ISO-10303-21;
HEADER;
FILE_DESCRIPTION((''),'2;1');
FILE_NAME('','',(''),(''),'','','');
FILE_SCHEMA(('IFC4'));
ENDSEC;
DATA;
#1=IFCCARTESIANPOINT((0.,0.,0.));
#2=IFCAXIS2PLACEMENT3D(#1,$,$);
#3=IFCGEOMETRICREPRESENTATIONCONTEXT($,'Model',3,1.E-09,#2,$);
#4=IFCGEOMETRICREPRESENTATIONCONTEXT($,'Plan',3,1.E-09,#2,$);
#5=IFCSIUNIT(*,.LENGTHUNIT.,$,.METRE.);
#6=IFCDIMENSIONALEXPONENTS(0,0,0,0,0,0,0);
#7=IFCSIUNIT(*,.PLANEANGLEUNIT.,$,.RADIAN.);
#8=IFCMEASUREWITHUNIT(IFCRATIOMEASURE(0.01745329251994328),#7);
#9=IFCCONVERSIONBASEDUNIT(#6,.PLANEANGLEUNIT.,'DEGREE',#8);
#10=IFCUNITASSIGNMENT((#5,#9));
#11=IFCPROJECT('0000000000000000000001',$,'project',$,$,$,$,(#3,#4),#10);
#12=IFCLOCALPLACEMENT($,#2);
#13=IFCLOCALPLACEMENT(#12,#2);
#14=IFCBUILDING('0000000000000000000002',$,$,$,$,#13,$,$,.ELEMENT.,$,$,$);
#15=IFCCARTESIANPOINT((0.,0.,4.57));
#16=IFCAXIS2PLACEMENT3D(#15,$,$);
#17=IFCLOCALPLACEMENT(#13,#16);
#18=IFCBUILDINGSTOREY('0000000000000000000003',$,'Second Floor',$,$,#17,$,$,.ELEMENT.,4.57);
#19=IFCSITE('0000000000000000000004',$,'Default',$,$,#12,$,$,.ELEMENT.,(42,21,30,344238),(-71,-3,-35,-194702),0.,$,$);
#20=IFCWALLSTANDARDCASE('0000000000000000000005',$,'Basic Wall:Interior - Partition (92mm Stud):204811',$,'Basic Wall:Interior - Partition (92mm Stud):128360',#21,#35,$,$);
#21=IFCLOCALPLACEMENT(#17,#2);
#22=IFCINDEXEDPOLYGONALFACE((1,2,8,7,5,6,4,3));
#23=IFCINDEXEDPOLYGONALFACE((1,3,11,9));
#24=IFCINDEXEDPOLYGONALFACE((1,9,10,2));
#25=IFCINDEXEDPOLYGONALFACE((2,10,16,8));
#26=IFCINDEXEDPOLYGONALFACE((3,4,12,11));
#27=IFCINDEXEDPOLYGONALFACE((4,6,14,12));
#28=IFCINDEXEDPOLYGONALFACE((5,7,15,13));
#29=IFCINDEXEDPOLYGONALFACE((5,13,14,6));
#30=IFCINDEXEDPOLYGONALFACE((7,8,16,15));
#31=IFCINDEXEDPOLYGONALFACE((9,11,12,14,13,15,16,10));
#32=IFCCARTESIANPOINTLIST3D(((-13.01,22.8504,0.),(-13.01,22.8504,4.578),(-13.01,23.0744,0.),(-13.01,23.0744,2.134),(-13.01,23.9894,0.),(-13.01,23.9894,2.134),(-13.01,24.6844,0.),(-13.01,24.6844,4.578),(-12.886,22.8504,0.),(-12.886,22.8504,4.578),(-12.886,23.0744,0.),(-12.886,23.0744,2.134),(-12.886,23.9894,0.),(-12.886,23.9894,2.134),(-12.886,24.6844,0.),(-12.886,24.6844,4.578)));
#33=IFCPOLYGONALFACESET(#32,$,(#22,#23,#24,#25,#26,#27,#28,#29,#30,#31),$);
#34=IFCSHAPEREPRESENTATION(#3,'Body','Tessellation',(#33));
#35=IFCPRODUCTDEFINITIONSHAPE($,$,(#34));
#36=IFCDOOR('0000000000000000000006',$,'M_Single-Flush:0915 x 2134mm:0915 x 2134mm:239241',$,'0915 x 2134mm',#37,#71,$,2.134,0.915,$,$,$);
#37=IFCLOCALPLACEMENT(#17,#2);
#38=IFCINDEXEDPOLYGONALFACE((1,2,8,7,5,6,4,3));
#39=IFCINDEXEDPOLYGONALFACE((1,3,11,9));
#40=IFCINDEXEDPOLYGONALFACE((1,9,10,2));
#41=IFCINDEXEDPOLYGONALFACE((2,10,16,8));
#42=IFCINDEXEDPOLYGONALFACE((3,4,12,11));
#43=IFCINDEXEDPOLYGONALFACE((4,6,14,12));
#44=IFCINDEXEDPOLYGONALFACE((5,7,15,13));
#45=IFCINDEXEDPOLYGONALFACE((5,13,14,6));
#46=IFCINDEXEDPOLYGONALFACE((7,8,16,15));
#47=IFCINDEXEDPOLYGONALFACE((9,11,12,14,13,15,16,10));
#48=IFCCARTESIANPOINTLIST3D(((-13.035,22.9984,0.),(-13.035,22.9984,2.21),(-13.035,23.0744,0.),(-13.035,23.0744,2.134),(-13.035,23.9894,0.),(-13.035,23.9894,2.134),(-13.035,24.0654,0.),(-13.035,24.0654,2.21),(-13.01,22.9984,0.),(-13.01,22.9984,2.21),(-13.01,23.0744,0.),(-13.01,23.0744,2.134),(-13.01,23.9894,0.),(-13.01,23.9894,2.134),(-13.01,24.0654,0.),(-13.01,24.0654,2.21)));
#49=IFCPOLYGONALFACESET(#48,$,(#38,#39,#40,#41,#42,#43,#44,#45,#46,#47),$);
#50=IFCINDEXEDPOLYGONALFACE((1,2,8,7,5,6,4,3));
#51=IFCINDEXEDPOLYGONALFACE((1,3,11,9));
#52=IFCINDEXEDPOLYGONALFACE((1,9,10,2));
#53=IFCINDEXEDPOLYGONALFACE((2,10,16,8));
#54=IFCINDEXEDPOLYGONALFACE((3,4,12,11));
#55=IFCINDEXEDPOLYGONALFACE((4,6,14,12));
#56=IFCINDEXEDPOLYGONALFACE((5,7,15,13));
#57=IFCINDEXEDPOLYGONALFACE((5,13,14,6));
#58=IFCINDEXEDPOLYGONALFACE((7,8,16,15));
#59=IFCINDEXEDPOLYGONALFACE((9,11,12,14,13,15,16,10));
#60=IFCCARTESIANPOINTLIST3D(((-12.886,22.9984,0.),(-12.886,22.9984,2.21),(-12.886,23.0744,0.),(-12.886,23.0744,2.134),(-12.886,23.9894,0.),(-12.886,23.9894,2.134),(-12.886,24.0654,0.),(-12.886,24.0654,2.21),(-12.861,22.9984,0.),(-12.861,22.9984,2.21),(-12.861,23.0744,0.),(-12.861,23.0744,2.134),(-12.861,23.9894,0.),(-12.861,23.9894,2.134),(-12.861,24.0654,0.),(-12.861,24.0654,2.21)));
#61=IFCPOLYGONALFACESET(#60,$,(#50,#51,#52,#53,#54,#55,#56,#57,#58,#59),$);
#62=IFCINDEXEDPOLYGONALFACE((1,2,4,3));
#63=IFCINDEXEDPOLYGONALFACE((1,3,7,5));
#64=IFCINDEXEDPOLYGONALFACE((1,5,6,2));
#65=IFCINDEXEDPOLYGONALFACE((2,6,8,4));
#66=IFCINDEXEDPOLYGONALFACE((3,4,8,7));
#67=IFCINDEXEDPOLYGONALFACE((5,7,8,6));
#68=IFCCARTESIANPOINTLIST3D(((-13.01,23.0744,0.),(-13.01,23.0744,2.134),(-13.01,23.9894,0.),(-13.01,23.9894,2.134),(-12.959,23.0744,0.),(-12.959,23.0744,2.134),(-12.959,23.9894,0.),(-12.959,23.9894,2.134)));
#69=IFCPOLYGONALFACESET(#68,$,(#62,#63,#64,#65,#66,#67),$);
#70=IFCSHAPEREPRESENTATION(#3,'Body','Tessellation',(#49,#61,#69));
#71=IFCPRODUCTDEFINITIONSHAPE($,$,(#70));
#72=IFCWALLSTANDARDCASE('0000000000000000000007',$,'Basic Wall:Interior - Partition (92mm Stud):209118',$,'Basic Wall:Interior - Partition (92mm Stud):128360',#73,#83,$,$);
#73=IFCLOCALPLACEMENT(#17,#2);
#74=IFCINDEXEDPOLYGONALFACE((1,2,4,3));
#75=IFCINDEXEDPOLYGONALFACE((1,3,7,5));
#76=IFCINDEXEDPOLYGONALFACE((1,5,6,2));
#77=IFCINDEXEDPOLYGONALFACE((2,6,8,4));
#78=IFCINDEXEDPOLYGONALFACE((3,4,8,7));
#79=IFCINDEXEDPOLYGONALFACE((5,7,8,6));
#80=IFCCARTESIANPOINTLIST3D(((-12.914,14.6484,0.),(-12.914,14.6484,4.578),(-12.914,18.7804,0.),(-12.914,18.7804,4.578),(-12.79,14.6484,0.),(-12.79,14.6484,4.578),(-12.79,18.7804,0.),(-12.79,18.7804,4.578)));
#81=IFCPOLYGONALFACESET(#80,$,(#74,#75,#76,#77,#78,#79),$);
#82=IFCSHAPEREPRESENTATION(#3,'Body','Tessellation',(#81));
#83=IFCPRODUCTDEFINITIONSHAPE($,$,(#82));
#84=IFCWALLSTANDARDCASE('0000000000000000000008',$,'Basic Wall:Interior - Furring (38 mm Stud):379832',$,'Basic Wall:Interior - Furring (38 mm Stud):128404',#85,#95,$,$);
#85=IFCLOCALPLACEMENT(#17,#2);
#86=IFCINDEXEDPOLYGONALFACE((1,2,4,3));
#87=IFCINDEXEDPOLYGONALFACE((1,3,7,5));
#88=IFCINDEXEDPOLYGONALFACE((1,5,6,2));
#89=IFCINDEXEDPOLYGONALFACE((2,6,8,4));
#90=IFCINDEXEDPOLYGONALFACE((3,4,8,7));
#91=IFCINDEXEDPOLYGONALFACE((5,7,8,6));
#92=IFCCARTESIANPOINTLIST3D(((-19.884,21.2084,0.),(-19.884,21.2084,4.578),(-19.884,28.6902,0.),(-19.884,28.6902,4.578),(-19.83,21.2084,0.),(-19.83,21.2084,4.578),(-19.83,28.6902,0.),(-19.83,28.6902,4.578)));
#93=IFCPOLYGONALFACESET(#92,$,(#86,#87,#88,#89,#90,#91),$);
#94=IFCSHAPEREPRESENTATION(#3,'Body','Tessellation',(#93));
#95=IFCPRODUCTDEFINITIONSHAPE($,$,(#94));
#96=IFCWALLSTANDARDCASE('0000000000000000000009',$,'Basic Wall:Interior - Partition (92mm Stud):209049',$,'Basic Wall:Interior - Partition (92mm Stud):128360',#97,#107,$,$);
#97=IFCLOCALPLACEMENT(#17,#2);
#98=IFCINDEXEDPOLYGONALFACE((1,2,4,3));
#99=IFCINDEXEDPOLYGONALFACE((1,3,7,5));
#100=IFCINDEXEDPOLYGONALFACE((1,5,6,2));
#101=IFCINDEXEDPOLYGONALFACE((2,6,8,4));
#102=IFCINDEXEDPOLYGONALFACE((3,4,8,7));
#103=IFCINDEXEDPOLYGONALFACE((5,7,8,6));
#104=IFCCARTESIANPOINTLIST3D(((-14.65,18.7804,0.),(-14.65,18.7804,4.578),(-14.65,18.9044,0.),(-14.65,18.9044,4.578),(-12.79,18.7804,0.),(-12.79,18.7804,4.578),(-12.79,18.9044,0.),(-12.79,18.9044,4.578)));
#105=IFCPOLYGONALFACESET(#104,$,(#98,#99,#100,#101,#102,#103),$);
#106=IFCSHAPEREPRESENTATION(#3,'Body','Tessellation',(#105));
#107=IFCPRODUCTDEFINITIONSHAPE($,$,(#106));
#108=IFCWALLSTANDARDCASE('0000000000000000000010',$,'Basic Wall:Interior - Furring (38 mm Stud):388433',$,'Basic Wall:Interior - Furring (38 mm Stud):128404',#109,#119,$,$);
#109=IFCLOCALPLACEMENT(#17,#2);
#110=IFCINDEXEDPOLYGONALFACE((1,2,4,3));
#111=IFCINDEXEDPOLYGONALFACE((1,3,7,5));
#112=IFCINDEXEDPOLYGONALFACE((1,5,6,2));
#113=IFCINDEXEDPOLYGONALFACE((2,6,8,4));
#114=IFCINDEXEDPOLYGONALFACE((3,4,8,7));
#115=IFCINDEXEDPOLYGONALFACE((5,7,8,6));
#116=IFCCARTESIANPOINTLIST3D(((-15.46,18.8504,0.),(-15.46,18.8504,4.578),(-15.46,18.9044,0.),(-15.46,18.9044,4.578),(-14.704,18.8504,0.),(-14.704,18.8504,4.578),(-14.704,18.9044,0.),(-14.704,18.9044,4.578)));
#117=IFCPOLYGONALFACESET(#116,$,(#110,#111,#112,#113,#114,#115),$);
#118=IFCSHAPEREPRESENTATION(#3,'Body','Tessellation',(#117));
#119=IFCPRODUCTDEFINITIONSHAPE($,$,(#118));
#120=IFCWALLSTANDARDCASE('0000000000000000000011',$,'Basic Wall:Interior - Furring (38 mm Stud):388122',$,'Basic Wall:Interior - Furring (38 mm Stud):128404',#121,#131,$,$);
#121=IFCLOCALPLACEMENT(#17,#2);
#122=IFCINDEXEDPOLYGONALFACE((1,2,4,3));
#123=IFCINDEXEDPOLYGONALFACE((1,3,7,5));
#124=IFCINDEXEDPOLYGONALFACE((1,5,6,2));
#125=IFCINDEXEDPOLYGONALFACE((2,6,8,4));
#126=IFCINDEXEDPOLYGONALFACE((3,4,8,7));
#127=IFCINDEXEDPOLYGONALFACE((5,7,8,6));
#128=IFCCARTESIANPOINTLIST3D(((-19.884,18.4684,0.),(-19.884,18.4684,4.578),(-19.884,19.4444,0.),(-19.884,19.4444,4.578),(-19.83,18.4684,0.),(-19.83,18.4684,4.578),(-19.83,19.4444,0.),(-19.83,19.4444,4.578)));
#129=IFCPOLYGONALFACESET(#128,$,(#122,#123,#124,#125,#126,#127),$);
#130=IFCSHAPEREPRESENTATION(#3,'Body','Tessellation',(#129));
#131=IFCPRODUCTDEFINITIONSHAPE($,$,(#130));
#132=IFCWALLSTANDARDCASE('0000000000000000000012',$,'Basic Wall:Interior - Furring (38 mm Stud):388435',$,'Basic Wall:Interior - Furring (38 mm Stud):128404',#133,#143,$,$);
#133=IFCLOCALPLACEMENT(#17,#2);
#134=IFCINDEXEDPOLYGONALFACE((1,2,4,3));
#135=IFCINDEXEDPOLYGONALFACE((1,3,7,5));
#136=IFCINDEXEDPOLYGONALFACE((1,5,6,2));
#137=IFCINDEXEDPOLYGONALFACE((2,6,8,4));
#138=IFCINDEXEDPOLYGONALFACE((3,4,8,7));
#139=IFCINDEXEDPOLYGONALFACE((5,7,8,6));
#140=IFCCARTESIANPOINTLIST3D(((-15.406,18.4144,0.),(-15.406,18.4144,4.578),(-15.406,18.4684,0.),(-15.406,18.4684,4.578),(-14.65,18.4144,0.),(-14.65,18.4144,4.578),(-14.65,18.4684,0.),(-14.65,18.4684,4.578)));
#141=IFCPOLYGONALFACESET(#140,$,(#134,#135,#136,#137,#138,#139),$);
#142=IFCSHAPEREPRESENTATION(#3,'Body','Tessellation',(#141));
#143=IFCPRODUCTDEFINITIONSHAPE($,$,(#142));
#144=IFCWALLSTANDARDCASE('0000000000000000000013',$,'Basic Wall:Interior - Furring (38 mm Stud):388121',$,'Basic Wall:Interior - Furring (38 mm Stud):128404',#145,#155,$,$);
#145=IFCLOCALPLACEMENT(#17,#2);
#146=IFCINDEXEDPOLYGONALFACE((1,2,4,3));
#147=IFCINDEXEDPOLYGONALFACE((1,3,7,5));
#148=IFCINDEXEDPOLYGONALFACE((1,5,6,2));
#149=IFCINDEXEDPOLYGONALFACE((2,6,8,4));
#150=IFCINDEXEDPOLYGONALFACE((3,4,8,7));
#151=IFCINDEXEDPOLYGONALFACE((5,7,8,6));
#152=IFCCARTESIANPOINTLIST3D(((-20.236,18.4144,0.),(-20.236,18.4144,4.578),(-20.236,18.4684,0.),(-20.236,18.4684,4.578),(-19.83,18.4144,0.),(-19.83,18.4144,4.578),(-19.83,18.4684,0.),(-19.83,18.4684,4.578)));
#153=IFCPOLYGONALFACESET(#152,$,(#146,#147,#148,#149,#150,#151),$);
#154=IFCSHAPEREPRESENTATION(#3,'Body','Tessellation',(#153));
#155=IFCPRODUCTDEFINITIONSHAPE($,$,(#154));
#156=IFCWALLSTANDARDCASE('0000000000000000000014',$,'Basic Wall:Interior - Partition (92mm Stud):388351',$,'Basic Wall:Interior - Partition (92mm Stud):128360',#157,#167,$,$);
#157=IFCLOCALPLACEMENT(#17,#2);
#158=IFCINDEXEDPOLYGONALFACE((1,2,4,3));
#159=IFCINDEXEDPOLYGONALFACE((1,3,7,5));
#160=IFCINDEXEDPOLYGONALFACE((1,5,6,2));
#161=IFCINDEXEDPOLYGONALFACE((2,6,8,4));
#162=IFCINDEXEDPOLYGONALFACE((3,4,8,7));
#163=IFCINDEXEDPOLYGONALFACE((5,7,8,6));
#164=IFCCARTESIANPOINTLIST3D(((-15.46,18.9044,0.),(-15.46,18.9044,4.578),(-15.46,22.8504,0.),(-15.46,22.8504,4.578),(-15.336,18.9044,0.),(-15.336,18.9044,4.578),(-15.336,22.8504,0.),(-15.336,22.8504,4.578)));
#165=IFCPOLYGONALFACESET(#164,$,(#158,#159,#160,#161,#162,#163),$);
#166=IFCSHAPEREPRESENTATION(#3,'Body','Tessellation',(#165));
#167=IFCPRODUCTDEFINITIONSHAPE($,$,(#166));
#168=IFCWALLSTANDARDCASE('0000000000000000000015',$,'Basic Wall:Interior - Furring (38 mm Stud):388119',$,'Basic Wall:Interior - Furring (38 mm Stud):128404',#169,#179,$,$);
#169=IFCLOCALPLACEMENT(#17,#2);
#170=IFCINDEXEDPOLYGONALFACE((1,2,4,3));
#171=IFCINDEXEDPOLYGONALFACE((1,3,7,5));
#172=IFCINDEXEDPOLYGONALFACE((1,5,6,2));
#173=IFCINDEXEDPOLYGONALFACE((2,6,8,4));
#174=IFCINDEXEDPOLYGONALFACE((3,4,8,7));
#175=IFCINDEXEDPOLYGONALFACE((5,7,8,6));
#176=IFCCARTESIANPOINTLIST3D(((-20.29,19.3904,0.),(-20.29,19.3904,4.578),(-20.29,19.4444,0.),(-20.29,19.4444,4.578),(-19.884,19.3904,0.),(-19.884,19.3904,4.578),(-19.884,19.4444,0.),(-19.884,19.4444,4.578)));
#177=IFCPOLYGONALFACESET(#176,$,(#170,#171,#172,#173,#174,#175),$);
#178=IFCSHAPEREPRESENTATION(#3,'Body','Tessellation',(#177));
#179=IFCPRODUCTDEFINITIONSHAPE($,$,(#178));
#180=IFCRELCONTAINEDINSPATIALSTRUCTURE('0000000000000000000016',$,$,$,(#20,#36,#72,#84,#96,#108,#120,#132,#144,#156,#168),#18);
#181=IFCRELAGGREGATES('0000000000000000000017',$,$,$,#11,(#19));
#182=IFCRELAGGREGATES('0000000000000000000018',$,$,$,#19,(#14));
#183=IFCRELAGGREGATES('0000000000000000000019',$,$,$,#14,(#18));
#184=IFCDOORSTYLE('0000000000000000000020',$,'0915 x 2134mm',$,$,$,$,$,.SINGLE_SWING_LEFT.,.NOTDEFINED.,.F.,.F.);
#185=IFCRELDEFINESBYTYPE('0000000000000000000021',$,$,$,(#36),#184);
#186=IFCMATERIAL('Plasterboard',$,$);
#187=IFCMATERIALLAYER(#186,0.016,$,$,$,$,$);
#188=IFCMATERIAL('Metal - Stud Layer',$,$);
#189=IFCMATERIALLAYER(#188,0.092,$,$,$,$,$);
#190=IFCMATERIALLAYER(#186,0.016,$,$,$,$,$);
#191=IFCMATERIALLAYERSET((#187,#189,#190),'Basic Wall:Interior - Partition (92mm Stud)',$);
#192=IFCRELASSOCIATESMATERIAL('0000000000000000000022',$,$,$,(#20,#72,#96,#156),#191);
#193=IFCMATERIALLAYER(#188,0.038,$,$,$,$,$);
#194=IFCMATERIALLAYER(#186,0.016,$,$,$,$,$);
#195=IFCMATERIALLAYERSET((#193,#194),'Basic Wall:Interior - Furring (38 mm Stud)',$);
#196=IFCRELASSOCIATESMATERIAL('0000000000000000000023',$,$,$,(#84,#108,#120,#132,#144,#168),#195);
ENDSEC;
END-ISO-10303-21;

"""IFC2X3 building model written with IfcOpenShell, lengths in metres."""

from ifc_helpers import new_model, entity, si_unit, converted_unit, frame, frame_2d, origin, origin_2d_with_axis, place, context, project, spatial, polyline, rectangle, outline, extrude, source, transform, mapped, material, layer, layer_set, layer_usage, type_object, type_shapes, element, fill, save


model = new_model("IFC2X3")

# Units and contexts
model_context = context("Model", 3, precision=1e-09, world=origin())
plan_context = context("Plan", 3, precision=1e-09, world=origin())
ifc_project = project(units=[si_unit("LENGTHUNIT", "METRE"), converted_unit("PLANEANGLEUNIT", "DEGREE", entity("IfcRatioMeasure", 0.01745329251994328), si_unit("PLANEANGLEUNIT", "RADIAN"), dimensions=[0, 0, 0, 0, 0, 0, 0])], contexts=[model_context, plan_context])

# Site, building, storey
site_placement = place(None, origin())
site = spatial("IfcSite", under=ifc_project, at=site_placement, Name="Default", CompositionType="ELEMENT", RefLatitude=(42, 21, 30, 344238), RefLongitude=(-71, -3, -35, -194702), RefElevation=0.0)
building_placement = place(site_placement, origin())
building = spatial("IfcBuilding", under=site, at=building_placement, CompositionType="ELEMENT")
storey_placement = place(building_placement, frame((0.0, 0.0, 4.57)))
storey = spatial("IfcBuildingStorey", under=building, at=storey_placement, Name="Second Floor", CompositionType="ELEMENT", Elevation=4.57)

# Shared definitions
ifc_material_1 = material(Name="Plasterboard")
ifc_layer_1 = layer(ifc_material_1, 0.016)
ifc_material_2 = material(Name="Metal - Stud Layer")
ifc_layer_2 = layer(ifc_material_2, 0.092)
ifc_layer_3 = layer(ifc_material_1, 0.016)
ifc_layer_set_1 = layer_set([ifc_layer_1, ifc_layer_2, ifc_layer_3], Name="Basic Wall:Interior - Partition (92mm Stud)")
ifc_layer_usage_1 = layer_usage(ifc_layer_set_1, "AXIS2", "NEGATIVE", 0.062)
door_style_1 = type_object("IfcDoorStyle", Name="0915 x 2134mm", ConstructionType="NOTDEFINED", OperationType="SINGLE_SWING_LEFT", ParameterTakesPrecedence=False, Sizeable=False)
shared_shape_1 = source(origin(), model_context, "Body", "SweptSolid", [
    extrude(outline(polyline([(-0.5335, -1.124), (0.5335, -1.124), (0.5335, 1.086), (0.4575, 1.086), (0.4575, -1.048), (-0.4575, -1.048), (-0.4575, 1.086), (-0.5335, 1.086), (-0.5335, -1.124)])), frame((0.4575, 0.149, 1.086), z_axis=(0.0, -1.0, 0.0), x_axis=(-1.0, 0.0, 0.0)), (0.0, 0.0, 1.0), 0.025),
    extrude(outline(polyline([(-1.124, -0.5335), (1.086, -0.5335), (1.086, -0.4575), (-1.048, -0.4575), (-1.048, 0.4575), (1.086, 0.4575), (1.086, 0.5335), (-1.124, 0.5335), (-1.124, -0.5335)])), frame((0.4575, 0.0, 1.086), z_axis=(0.0, -1.0, 0.0), x_axis=(0.0, 0.0, -1.0)), (0.0, 0.0, 1.0), 0.025),
    extrude(rectangle(XDim=0.915, YDim=0.051, at=origin_2d_with_axis()), frame((0.4575, 0.0985, 0.0)), (0.0, 0.0, 1.0), 2.134),
])
type_shapes(door_style_1, [shared_shape_1])

# Shared definitions
ifc_layer_4 = layer(ifc_material_2, 0.038)
ifc_layer_5 = layer(ifc_material_1, 0.016)
ifc_layer_set_2 = layer_set([ifc_layer_4, ifc_layer_5], Name="Basic Wall:Interior - Furring (38 mm Stud)")
ifc_layer_usage_2 = layer_usage(ifc_layer_set_2, "AXIS2", "POSITIVE", -0.027)

# Wall, opening, door
wall_1_placement = place(storey_placement, frame((-12.948, 22.8504, 0.0), z_axis=(0.0, 0.0, 1.0), x_axis=(0.0, 1.0, 0.0)))
wall_1 = element("IfcWallStandardCase", 1, at=wall_1_placement, inside=storey, material=ifc_layer_usage_1, Name="Basic Wall:Interior - Partition (92mm Stud):204811", ObjectType="Basic Wall:Interior - Partition (92mm Stud):128360", context=model_context, shape_type="SweptSolid", body=[
    extrude(rectangle(XDim=1.834, YDim=0.124, at=frame_2d((0.917, 0.0), x_axis=(-1.0, 0.0))), origin(), (0.0, 0.0, 1.0), 4.578),
])
opening_1_placement = place(wall_1_placement, frame((0.224, -0.062, 0.0)))
opening_1 = element("IfcOpeningElement", 2, at=opening_1_placement, cuts=wall_1, ObjectType="Opening", context=model_context, shape_type="SweptSolid", body=[
    extrude(rectangle(XDim=0.915, YDim=2.134, at=frame_2d((1.067, 0.4575), x_axis=(0.0, -1.0))), frame((0.0, 0.0, 0.0), z_axis=(0.0, 1.0, 0.0), x_axis=(0.0, 0.0, 1.0)), (0.0, 0.0, 1.0), 0.124),
])
door_1_placement = place(opening_1_placement, origin())
door_1 = element("IfcDoor", 3, at=door_1_placement, inside=storey, type_object=door_style_1, Name="M_Single-Flush:0915 x 2134mm:0915 x 2134mm:239241", ObjectType="0915 x 2134mm", OverallHeight=2.134, OverallWidth=0.915, context=model_context, shape_type="MappedRepresentation", body=[
    mapped(shared_shape_1, transform((0.0, 0.0, 0.0), scale=1.0)),
])
fill(opening_1, door_1)

# Walls
wall_2_placement = place(storey_placement, frame((-12.852, 18.7804, 0.0), z_axis=(0.0, 0.0, 1.0), x_axis=(0.0, -1.0, 0.0)))
element("IfcWallStandardCase", 4, at=wall_2_placement, inside=storey, material=ifc_layer_usage_1, Name="Basic Wall:Interior - Partition (92mm Stud):209118", ObjectType="Basic Wall:Interior - Partition (92mm Stud):128360", context=model_context, shape_type="SweptSolid", body=[
    extrude(rectangle(XDim=4.132, YDim=0.124, at=frame_2d((2.066, 0.0), x_axis=(-1.0, 0.0))), origin(), (0.0, 0.0, 1.0), 4.578),
])
ifc_layer_usage_3 = layer_usage(ifc_layer_set_2, "AXIS2", "NEGATIVE", 0.027)
wall_3_placement = place(storey_placement, frame((-19.857, 21.2084, 0.0), z_axis=(0.0, 0.0, 1.0), x_axis=(0.0, 1.0, 0.0)))
element("IfcWallStandardCase", 5, at=wall_3_placement, inside=storey, material=ifc_layer_usage_3, Name="Basic Wall:Interior - Furring (38 mm Stud):379832", ObjectType="Basic Wall:Interior - Furring (38 mm Stud):128404", context=model_context, shape_type="SweptSolid", body=[
    extrude(rectangle(XDim=7.4818, YDim=0.054, at=frame_2d((3.7409, 0.0), x_axis=(-1.0, 0.0))), origin(), (0.0, 0.0, 1.0), 4.578),
])
wall_4_placement = place(storey_placement, frame((-14.65, 18.8424, 0.0)))
element("IfcWallStandardCase", 6, at=wall_4_placement, inside=storey, material=ifc_layer_usage_1, Name="Basic Wall:Interior - Partition (92mm Stud):209049", ObjectType="Basic Wall:Interior - Partition (92mm Stud):128360", context=model_context, shape_type="SweptSolid", body=[
    extrude(rectangle(XDim=1.86, YDim=0.124, at=frame_2d((0.93, 0.0), x_axis=(-1.0, 0.0))), origin(), (0.0, 0.0, 1.0), 4.578),
])
wall_5_placement = place(storey_placement, frame((-15.46, 18.8774, 0.0)))
element("IfcWallStandardCase", 7, at=wall_5_placement, inside=storey, material=ifc_layer_usage_2, Name="Basic Wall:Interior - Furring (38 mm Stud):388433", ObjectType="Basic Wall:Interior - Furring (38 mm Stud):128404", context=model_context, shape_type="SweptSolid", body=[
    extrude(rectangle(XDim=0.756, YDim=0.054, at=frame_2d((0.378, 0.0), x_axis=(-1.0, 0.0))), origin(), (0.0, 0.0, 1.0), 4.578),
])
wall_6_placement = place(storey_placement, frame((-19.857, 19.4444, 0.0), z_axis=(0.0, 0.0, 1.0), x_axis=(0.0, -1.0, 0.0)))
element("IfcWallStandardCase", 8, at=wall_6_placement, inside=storey, material=ifc_layer_usage_2, Name="Basic Wall:Interior - Furring (38 mm Stud):388122", ObjectType="Basic Wall:Interior - Furring (38 mm Stud):128404", context=model_context, shape_type="SweptSolid", body=[
    extrude(rectangle(XDim=0.976, YDim=0.054, at=frame_2d((0.488, 0.0), x_axis=(-1.0, 0.0))), origin(), (0.0, 0.0, 1.0), 4.578),
])
wall_7_placement = place(storey_placement, frame((-14.65, 18.4414, 0.0), z_axis=(0.0, 0.0, 1.0), x_axis=(-1.0, 0.0, 0.0)))
element("IfcWallStandardCase", 9, at=wall_7_placement, inside=storey, material=ifc_layer_usage_2, Name="Basic Wall:Interior - Furring (38 mm Stud):388435", ObjectType="Basic Wall:Interior - Furring (38 mm Stud):128404", context=model_context, shape_type="SweptSolid", body=[
    extrude(rectangle(XDim=0.756, YDim=0.054, at=frame_2d((0.378, 0.0), x_axis=(-1.0, 0.0))), origin(), (0.0, 0.0, 1.0), 4.578),
])
wall_8_placement = place(storey_placement, frame((-19.83, 18.4414, 0.0), z_axis=(0.0, 0.0, 1.0), x_axis=(-1.0, 0.0, 0.0)))
element("IfcWallStandardCase", 10, at=wall_8_placement, inside=storey, material=ifc_layer_usage_2, Name="Basic Wall:Interior - Furring (38 mm Stud):388121", ObjectType="Basic Wall:Interior - Furring (38 mm Stud):128404", context=model_context, shape_type="SweptSolid", body=[
    extrude(rectangle(XDim=0.406, YDim=0.054, at=frame_2d((0.203, 0.0), x_axis=(-1.0, 0.0))), origin(), (0.0, 0.0, 1.0), 4.578),
])
wall_9_placement = place(storey_placement, frame((-15.398, 18.9044, 0.0), z_axis=(0.0, 0.0, 1.0), x_axis=(0.0, 1.0, 0.0)))
element("IfcWallStandardCase", 11, at=wall_9_placement, inside=storey, material=ifc_layer_usage_1, Name="Basic Wall:Interior - Partition (92mm Stud):388351", ObjectType="Basic Wall:Interior - Partition (92mm Stud):128360", context=model_context, shape_type="SweptSolid", body=[
    extrude(rectangle(XDim=3.946, YDim=0.124, at=frame_2d((1.973, 0.0), x_axis=(-1.0, 0.0))), origin(), (0.0, 0.0, 1.0), 4.578),
])
wall_10_placement = place(storey_placement, frame((-20.29, 19.4174, 0.0)))
element("IfcWallStandardCase", 12, at=wall_10_placement, inside=storey, material=ifc_layer_usage_2, Name="Basic Wall:Interior - Furring (38 mm Stud):388119", ObjectType="Basic Wall:Interior - Furring (38 mm Stud):128404", context=model_context, shape_type="SweptSolid", body=[
    extrude(rectangle(XDim=0.406, YDim=0.054, at=frame_2d((0.203, 0.0), x_axis=(-1.0, 0.0))), origin(), (0.0, 0.0, 1.0), 4.578),
])

save(model, "model.ifc")
